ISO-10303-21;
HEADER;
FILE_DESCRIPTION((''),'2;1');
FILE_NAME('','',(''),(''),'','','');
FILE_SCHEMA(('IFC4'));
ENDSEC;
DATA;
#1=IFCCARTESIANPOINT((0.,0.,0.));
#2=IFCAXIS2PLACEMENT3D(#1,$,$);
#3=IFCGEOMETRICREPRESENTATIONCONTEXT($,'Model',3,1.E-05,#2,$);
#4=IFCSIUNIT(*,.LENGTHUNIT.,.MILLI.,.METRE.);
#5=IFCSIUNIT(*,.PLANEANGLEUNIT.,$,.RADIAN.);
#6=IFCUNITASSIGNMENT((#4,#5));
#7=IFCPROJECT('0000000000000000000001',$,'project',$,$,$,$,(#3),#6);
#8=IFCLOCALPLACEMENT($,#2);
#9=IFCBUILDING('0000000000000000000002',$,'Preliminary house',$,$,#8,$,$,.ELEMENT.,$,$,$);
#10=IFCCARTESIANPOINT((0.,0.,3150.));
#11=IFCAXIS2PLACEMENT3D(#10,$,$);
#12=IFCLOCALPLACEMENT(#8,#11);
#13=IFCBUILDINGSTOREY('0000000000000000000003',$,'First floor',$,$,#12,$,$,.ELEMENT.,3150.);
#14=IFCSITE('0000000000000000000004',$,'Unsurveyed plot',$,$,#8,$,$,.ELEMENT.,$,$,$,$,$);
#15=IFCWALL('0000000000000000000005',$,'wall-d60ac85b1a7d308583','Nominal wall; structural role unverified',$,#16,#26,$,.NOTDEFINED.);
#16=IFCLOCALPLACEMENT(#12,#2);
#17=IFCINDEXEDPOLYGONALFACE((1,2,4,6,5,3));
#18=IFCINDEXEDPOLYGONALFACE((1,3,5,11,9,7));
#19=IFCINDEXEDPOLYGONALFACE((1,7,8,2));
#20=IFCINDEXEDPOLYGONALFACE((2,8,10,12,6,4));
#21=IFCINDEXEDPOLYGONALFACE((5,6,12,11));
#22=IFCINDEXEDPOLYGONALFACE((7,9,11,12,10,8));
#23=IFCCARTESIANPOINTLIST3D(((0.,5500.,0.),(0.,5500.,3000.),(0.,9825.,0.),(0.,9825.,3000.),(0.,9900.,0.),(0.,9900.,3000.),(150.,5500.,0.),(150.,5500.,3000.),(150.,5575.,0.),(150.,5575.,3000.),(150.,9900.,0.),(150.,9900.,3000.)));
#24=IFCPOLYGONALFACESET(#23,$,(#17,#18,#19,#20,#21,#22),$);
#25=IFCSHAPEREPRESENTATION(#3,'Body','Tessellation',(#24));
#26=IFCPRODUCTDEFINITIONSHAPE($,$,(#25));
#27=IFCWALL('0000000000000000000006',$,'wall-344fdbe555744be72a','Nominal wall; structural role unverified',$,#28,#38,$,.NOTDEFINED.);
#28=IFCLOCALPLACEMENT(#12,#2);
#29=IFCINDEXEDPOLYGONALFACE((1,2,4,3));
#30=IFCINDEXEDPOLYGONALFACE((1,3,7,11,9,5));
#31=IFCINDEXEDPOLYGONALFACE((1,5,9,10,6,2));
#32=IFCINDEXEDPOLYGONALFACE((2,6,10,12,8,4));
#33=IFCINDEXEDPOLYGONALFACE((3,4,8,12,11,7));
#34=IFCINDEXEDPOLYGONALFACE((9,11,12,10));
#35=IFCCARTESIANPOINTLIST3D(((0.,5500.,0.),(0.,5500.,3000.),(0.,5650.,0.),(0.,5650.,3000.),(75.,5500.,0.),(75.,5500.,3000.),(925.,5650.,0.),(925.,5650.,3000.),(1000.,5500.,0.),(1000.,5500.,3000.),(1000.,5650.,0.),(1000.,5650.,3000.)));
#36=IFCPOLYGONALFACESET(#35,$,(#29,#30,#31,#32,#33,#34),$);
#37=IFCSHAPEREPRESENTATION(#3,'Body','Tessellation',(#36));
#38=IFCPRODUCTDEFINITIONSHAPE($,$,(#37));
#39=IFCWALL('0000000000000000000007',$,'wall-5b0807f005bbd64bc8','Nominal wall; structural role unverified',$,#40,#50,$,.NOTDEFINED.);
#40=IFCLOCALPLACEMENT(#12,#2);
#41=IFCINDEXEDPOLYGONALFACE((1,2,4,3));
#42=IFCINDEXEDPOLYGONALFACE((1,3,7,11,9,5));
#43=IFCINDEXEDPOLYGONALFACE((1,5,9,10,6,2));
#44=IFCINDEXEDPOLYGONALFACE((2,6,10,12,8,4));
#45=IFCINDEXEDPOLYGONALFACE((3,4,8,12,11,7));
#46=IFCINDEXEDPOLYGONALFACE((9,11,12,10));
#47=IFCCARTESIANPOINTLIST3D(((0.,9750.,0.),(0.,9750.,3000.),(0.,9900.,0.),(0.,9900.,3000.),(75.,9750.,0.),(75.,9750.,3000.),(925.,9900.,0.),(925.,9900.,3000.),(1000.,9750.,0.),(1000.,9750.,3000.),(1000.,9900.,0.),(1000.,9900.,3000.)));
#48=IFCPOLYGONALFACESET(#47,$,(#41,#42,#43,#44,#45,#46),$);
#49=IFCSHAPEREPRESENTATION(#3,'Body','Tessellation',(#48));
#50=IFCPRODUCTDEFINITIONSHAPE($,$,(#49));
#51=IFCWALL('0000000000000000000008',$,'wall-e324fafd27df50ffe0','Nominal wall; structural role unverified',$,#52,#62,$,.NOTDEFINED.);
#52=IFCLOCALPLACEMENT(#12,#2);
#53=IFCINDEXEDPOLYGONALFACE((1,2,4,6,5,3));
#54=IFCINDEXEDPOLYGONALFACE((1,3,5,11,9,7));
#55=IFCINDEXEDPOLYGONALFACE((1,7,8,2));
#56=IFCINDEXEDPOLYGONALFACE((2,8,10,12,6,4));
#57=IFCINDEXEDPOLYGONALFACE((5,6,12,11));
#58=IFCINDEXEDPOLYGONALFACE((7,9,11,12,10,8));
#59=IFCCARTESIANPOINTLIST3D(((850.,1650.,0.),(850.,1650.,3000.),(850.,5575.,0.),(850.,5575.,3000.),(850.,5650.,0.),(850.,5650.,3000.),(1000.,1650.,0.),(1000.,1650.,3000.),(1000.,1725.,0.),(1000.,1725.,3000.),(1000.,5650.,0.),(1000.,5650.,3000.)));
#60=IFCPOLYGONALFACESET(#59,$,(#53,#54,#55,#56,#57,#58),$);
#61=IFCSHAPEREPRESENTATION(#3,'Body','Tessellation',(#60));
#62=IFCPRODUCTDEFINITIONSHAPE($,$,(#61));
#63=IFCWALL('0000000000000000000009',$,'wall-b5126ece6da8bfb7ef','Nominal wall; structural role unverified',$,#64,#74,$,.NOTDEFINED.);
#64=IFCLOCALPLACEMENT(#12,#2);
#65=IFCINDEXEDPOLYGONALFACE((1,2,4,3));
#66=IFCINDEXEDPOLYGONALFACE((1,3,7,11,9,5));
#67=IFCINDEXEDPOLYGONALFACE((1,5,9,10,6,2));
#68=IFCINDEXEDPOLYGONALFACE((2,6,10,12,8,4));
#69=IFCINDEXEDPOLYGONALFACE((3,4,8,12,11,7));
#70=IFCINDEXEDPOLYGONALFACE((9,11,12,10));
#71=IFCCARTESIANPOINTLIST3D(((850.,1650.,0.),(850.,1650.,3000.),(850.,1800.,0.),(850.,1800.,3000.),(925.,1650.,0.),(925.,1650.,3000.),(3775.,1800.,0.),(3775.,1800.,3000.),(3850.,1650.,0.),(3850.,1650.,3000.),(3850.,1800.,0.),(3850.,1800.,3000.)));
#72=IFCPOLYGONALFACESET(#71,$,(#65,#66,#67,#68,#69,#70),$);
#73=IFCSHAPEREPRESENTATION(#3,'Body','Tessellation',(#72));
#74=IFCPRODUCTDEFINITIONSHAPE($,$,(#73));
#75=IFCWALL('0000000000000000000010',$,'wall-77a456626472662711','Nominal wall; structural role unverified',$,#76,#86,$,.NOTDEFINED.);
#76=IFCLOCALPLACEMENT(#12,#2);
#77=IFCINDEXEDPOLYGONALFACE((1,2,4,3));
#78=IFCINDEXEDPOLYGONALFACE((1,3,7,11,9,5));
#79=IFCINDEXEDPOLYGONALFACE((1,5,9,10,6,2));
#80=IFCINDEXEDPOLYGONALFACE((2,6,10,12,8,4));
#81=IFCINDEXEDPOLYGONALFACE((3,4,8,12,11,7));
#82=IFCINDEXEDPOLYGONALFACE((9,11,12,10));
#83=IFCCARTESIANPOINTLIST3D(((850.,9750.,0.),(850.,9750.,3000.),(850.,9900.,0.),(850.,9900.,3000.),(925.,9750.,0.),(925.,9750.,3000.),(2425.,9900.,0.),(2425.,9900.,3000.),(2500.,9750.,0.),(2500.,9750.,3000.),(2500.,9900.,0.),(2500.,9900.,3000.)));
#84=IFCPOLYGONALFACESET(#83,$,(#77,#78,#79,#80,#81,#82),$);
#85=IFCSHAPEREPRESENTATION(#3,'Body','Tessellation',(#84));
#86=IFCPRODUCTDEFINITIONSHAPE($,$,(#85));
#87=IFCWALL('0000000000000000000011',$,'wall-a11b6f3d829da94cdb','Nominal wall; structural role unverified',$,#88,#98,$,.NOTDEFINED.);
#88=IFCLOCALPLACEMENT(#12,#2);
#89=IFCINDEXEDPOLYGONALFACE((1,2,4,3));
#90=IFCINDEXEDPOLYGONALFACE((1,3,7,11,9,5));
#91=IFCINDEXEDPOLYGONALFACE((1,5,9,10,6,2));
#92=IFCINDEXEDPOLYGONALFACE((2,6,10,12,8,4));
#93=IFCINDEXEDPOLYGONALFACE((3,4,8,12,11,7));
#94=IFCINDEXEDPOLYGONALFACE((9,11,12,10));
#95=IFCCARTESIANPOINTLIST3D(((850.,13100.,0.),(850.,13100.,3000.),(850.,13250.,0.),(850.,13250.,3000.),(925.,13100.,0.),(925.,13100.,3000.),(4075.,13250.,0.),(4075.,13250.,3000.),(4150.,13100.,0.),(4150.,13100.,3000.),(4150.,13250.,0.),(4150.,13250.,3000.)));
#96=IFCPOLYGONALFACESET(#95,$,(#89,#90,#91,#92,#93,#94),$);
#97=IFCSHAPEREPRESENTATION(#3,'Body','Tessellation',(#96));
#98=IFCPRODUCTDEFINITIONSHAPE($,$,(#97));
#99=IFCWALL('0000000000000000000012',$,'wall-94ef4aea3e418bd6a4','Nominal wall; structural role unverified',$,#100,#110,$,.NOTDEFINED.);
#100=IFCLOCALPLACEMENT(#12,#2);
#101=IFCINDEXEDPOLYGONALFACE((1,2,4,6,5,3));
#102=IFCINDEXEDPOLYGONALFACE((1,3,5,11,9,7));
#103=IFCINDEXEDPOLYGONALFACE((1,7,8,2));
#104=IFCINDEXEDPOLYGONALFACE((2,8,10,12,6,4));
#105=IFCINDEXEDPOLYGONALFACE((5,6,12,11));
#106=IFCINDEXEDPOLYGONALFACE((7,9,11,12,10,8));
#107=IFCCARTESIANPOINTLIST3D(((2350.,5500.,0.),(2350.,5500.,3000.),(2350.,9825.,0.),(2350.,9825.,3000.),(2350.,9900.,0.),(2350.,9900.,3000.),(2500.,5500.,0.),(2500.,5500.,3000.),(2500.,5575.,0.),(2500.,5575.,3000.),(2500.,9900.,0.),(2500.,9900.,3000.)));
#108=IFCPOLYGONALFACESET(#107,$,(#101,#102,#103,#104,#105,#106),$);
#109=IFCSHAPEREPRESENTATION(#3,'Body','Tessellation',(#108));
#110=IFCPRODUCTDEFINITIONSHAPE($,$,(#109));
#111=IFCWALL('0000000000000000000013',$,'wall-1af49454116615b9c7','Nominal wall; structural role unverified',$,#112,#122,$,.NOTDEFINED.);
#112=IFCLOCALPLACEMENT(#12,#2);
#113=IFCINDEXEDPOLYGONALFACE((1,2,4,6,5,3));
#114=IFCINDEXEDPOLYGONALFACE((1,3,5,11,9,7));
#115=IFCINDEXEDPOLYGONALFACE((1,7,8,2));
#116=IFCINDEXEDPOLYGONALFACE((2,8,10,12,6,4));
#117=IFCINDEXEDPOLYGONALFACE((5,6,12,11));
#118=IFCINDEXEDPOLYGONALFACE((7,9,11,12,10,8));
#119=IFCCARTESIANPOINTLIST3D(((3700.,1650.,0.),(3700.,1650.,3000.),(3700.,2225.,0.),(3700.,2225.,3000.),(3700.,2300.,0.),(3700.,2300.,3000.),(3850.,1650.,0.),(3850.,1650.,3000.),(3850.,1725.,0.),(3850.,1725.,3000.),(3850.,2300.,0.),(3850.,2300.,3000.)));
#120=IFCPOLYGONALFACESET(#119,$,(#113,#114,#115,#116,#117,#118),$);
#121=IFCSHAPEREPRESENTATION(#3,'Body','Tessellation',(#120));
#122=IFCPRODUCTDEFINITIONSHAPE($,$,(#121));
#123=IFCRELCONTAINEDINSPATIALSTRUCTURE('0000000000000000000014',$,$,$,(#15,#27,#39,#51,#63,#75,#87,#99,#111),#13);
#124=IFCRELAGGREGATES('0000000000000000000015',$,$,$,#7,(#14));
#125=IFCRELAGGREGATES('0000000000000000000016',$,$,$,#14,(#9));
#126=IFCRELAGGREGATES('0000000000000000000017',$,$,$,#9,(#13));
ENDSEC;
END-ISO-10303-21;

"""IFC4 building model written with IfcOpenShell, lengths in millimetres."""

from ifc_helpers import new_model, si_unit, frame, origin, place, context, project, spatial, polyline, outline, extrude, element, save


model = new_model("IFC4")

# Units and contexts
model_context = context("Model", 3, precision=1e-05, world=origin())
ifc_project = project(units=[si_unit("LENGTHUNIT", "METRE", prefix="MILLI"), si_unit("PLANEANGLEUNIT", "RADIAN")], contexts=[model_context])

# Site, building, storey
placement_1 = place(None, origin())
site = spatial("IfcSite", under=ifc_project, at=placement_1, Name="Unsurveyed plot", CompositionType="ELEMENT")
building = spatial("IfcBuilding", under=site, at=placement_1, Name="Preliminary house", CompositionType="ELEMENT")
placement_2 = place(placement_1, frame((0.0, 0.0, 3150.0)))
storey = spatial("IfcBuildingStorey", under=building, at=placement_2, Name="First floor", CompositionType="ELEMENT", Elevation=3150.0)

# Walls
element("IfcWall", 1, at=placement_2, inside=storey, Name="wall-d60ac85b1a7d308583", Description="Nominal wall; structural role unverified", PredefinedType="NOTDEFINED", context=model_context, shape_type="SweptSolid", body=[
    extrude(outline(polyline([(0.0, 9825.0), (0.0, 9900.0), (150.0, 9900.0), (150.0, 5575.0), (150.0, 5500.0), (0.0, 5500.0), (0.0, 9825.0)])), origin(), (0.0, 0.0, 1.0), 3000.0),
])
element("IfcWall", 2, at=placement_2, inside=storey, Name="wall-344fdbe555744be72a", Description="Nominal wall; structural role unverified", PredefinedType="NOTDEFINED", context=model_context, shape_type="SweptSolid", body=[
    extrude(outline(polyline([(925.0, 5650.0), (1000.0, 5650.0), (1000.0, 5500.0), (75.0, 5500.0), (0.0, 5500.0), (0.0, 5650.0), (925.0, 5650.0)])), origin(), (0.0, 0.0, 1.0), 3000.0),
])
element("IfcWall", 3, at=placement_2, inside=storey, Name="wall-5b0807f005bbd64bc8", Description="Nominal wall; structural role unverified", PredefinedType="NOTDEFINED", context=model_context, shape_type="SweptSolid", body=[
    extrude(outline(polyline([(925.0, 9900.0), (1000.0, 9900.0), (1000.0, 9750.0), (75.0, 9750.0), (0.0, 9750.0), (0.0, 9900.0), (925.0, 9900.0)])), origin(), (0.0, 0.0, 1.0), 3000.0),
])
element("IfcWall", 4, at=placement_2, inside=storey, Name="wall-e324fafd27df50ffe0", Description="Nominal wall; structural role unverified", PredefinedType="NOTDEFINED", context=model_context, shape_type="SweptSolid", body=[
    extrude(outline(polyline([(850.0, 5575.0), (850.0, 5650.0), (1000.0, 5650.0), (1000.0, 1725.0), (1000.0, 1650.0), (850.0, 1650.0), (850.0, 5575.0)])), origin(), (0.0, 0.0, 1.0), 3000.0),
])
element("IfcWall", 5, at=placement_2, inside=storey, Name="wall-b5126ece6da8bfb7ef", Description="Nominal wall; structural role unverified", PredefinedType="NOTDEFINED", context=model_context, shape_type="SweptSolid", body=[
    extrude(outline(polyline([(3775.0, 1800.0), (3850.0, 1800.0), (3850.0, 1650.0), (925.0, 1650.0), (850.0, 1650.0), (850.0, 1800.0), (3775.0, 1800.0)])), origin(), (0.0, 0.0, 1.0), 3000.0),
])

# Walls
element("IfcWall", 6, at=placement_2, inside=storey, Name="wall-77a456626472662711", Description="Nominal wall; structural role unverified", PredefinedType="NOTDEFINED", context=model_context, shape_type="SweptSolid", body=[
    extrude(outline(polyline([(2425.0, 9900.0), (2500.0, 9900.0), (2500.0, 9750.0), (925.0, 9750.0), (850.0, 9750.0), (850.0, 9900.0), (2425.0, 9900.0)])), origin(), (0.0, 0.0, 1.0), 3000.0),
])
element("IfcWall", 7, at=placement_2, inside=storey, Name="wall-a11b6f3d829da94cdb", Description="Nominal wall; structural role unverified", PredefinedType="NOTDEFINED", context=model_context, shape_type="SweptSolid", body=[
    extrude(outline(polyline([(4075.0, 13250.0), (4150.0, 13250.0), (4150.0, 13100.0), (925.0, 13100.0), (850.0, 13100.0), (850.0, 13250.0), (4075.0, 13250.0)])), origin(), (0.0, 0.0, 1.0), 3000.0),
])
element("IfcWall", 8, at=placement_2, inside=storey, Name="wall-94ef4aea3e418bd6a4", Description="Nominal wall; structural role unverified", PredefinedType="NOTDEFINED", context=model_context, shape_type="SweptSolid", body=[
    extrude(outline(polyline([(2350.0, 9825.0), (2350.0, 9900.0), (2500.0, 9900.0), (2500.0, 5575.0), (2500.0, 5500.0), (2350.0, 5500.0), (2350.0, 9825.0)])), origin(), (0.0, 0.0, 1.0), 3000.0),
])

# Wall
element("IfcWall", 9, at=placement_2, inside=storey, Name="wall-1af49454116615b9c7", Description="Nominal wall; structural role unverified", PredefinedType="NOTDEFINED", context=model_context, shape_type="SweptSolid", body=[
    extrude(outline(polyline([(3700.0, 2225.0), (3700.0, 2300.0), (3850.0, 2300.0), (3850.0, 1725.0), (3850.0, 1650.0), (3700.0, 1650.0), (3700.0, 2225.0)])), origin(), (0.0, 0.0, 1.0), 3000.0),
])

save(model, "model.ifc")
